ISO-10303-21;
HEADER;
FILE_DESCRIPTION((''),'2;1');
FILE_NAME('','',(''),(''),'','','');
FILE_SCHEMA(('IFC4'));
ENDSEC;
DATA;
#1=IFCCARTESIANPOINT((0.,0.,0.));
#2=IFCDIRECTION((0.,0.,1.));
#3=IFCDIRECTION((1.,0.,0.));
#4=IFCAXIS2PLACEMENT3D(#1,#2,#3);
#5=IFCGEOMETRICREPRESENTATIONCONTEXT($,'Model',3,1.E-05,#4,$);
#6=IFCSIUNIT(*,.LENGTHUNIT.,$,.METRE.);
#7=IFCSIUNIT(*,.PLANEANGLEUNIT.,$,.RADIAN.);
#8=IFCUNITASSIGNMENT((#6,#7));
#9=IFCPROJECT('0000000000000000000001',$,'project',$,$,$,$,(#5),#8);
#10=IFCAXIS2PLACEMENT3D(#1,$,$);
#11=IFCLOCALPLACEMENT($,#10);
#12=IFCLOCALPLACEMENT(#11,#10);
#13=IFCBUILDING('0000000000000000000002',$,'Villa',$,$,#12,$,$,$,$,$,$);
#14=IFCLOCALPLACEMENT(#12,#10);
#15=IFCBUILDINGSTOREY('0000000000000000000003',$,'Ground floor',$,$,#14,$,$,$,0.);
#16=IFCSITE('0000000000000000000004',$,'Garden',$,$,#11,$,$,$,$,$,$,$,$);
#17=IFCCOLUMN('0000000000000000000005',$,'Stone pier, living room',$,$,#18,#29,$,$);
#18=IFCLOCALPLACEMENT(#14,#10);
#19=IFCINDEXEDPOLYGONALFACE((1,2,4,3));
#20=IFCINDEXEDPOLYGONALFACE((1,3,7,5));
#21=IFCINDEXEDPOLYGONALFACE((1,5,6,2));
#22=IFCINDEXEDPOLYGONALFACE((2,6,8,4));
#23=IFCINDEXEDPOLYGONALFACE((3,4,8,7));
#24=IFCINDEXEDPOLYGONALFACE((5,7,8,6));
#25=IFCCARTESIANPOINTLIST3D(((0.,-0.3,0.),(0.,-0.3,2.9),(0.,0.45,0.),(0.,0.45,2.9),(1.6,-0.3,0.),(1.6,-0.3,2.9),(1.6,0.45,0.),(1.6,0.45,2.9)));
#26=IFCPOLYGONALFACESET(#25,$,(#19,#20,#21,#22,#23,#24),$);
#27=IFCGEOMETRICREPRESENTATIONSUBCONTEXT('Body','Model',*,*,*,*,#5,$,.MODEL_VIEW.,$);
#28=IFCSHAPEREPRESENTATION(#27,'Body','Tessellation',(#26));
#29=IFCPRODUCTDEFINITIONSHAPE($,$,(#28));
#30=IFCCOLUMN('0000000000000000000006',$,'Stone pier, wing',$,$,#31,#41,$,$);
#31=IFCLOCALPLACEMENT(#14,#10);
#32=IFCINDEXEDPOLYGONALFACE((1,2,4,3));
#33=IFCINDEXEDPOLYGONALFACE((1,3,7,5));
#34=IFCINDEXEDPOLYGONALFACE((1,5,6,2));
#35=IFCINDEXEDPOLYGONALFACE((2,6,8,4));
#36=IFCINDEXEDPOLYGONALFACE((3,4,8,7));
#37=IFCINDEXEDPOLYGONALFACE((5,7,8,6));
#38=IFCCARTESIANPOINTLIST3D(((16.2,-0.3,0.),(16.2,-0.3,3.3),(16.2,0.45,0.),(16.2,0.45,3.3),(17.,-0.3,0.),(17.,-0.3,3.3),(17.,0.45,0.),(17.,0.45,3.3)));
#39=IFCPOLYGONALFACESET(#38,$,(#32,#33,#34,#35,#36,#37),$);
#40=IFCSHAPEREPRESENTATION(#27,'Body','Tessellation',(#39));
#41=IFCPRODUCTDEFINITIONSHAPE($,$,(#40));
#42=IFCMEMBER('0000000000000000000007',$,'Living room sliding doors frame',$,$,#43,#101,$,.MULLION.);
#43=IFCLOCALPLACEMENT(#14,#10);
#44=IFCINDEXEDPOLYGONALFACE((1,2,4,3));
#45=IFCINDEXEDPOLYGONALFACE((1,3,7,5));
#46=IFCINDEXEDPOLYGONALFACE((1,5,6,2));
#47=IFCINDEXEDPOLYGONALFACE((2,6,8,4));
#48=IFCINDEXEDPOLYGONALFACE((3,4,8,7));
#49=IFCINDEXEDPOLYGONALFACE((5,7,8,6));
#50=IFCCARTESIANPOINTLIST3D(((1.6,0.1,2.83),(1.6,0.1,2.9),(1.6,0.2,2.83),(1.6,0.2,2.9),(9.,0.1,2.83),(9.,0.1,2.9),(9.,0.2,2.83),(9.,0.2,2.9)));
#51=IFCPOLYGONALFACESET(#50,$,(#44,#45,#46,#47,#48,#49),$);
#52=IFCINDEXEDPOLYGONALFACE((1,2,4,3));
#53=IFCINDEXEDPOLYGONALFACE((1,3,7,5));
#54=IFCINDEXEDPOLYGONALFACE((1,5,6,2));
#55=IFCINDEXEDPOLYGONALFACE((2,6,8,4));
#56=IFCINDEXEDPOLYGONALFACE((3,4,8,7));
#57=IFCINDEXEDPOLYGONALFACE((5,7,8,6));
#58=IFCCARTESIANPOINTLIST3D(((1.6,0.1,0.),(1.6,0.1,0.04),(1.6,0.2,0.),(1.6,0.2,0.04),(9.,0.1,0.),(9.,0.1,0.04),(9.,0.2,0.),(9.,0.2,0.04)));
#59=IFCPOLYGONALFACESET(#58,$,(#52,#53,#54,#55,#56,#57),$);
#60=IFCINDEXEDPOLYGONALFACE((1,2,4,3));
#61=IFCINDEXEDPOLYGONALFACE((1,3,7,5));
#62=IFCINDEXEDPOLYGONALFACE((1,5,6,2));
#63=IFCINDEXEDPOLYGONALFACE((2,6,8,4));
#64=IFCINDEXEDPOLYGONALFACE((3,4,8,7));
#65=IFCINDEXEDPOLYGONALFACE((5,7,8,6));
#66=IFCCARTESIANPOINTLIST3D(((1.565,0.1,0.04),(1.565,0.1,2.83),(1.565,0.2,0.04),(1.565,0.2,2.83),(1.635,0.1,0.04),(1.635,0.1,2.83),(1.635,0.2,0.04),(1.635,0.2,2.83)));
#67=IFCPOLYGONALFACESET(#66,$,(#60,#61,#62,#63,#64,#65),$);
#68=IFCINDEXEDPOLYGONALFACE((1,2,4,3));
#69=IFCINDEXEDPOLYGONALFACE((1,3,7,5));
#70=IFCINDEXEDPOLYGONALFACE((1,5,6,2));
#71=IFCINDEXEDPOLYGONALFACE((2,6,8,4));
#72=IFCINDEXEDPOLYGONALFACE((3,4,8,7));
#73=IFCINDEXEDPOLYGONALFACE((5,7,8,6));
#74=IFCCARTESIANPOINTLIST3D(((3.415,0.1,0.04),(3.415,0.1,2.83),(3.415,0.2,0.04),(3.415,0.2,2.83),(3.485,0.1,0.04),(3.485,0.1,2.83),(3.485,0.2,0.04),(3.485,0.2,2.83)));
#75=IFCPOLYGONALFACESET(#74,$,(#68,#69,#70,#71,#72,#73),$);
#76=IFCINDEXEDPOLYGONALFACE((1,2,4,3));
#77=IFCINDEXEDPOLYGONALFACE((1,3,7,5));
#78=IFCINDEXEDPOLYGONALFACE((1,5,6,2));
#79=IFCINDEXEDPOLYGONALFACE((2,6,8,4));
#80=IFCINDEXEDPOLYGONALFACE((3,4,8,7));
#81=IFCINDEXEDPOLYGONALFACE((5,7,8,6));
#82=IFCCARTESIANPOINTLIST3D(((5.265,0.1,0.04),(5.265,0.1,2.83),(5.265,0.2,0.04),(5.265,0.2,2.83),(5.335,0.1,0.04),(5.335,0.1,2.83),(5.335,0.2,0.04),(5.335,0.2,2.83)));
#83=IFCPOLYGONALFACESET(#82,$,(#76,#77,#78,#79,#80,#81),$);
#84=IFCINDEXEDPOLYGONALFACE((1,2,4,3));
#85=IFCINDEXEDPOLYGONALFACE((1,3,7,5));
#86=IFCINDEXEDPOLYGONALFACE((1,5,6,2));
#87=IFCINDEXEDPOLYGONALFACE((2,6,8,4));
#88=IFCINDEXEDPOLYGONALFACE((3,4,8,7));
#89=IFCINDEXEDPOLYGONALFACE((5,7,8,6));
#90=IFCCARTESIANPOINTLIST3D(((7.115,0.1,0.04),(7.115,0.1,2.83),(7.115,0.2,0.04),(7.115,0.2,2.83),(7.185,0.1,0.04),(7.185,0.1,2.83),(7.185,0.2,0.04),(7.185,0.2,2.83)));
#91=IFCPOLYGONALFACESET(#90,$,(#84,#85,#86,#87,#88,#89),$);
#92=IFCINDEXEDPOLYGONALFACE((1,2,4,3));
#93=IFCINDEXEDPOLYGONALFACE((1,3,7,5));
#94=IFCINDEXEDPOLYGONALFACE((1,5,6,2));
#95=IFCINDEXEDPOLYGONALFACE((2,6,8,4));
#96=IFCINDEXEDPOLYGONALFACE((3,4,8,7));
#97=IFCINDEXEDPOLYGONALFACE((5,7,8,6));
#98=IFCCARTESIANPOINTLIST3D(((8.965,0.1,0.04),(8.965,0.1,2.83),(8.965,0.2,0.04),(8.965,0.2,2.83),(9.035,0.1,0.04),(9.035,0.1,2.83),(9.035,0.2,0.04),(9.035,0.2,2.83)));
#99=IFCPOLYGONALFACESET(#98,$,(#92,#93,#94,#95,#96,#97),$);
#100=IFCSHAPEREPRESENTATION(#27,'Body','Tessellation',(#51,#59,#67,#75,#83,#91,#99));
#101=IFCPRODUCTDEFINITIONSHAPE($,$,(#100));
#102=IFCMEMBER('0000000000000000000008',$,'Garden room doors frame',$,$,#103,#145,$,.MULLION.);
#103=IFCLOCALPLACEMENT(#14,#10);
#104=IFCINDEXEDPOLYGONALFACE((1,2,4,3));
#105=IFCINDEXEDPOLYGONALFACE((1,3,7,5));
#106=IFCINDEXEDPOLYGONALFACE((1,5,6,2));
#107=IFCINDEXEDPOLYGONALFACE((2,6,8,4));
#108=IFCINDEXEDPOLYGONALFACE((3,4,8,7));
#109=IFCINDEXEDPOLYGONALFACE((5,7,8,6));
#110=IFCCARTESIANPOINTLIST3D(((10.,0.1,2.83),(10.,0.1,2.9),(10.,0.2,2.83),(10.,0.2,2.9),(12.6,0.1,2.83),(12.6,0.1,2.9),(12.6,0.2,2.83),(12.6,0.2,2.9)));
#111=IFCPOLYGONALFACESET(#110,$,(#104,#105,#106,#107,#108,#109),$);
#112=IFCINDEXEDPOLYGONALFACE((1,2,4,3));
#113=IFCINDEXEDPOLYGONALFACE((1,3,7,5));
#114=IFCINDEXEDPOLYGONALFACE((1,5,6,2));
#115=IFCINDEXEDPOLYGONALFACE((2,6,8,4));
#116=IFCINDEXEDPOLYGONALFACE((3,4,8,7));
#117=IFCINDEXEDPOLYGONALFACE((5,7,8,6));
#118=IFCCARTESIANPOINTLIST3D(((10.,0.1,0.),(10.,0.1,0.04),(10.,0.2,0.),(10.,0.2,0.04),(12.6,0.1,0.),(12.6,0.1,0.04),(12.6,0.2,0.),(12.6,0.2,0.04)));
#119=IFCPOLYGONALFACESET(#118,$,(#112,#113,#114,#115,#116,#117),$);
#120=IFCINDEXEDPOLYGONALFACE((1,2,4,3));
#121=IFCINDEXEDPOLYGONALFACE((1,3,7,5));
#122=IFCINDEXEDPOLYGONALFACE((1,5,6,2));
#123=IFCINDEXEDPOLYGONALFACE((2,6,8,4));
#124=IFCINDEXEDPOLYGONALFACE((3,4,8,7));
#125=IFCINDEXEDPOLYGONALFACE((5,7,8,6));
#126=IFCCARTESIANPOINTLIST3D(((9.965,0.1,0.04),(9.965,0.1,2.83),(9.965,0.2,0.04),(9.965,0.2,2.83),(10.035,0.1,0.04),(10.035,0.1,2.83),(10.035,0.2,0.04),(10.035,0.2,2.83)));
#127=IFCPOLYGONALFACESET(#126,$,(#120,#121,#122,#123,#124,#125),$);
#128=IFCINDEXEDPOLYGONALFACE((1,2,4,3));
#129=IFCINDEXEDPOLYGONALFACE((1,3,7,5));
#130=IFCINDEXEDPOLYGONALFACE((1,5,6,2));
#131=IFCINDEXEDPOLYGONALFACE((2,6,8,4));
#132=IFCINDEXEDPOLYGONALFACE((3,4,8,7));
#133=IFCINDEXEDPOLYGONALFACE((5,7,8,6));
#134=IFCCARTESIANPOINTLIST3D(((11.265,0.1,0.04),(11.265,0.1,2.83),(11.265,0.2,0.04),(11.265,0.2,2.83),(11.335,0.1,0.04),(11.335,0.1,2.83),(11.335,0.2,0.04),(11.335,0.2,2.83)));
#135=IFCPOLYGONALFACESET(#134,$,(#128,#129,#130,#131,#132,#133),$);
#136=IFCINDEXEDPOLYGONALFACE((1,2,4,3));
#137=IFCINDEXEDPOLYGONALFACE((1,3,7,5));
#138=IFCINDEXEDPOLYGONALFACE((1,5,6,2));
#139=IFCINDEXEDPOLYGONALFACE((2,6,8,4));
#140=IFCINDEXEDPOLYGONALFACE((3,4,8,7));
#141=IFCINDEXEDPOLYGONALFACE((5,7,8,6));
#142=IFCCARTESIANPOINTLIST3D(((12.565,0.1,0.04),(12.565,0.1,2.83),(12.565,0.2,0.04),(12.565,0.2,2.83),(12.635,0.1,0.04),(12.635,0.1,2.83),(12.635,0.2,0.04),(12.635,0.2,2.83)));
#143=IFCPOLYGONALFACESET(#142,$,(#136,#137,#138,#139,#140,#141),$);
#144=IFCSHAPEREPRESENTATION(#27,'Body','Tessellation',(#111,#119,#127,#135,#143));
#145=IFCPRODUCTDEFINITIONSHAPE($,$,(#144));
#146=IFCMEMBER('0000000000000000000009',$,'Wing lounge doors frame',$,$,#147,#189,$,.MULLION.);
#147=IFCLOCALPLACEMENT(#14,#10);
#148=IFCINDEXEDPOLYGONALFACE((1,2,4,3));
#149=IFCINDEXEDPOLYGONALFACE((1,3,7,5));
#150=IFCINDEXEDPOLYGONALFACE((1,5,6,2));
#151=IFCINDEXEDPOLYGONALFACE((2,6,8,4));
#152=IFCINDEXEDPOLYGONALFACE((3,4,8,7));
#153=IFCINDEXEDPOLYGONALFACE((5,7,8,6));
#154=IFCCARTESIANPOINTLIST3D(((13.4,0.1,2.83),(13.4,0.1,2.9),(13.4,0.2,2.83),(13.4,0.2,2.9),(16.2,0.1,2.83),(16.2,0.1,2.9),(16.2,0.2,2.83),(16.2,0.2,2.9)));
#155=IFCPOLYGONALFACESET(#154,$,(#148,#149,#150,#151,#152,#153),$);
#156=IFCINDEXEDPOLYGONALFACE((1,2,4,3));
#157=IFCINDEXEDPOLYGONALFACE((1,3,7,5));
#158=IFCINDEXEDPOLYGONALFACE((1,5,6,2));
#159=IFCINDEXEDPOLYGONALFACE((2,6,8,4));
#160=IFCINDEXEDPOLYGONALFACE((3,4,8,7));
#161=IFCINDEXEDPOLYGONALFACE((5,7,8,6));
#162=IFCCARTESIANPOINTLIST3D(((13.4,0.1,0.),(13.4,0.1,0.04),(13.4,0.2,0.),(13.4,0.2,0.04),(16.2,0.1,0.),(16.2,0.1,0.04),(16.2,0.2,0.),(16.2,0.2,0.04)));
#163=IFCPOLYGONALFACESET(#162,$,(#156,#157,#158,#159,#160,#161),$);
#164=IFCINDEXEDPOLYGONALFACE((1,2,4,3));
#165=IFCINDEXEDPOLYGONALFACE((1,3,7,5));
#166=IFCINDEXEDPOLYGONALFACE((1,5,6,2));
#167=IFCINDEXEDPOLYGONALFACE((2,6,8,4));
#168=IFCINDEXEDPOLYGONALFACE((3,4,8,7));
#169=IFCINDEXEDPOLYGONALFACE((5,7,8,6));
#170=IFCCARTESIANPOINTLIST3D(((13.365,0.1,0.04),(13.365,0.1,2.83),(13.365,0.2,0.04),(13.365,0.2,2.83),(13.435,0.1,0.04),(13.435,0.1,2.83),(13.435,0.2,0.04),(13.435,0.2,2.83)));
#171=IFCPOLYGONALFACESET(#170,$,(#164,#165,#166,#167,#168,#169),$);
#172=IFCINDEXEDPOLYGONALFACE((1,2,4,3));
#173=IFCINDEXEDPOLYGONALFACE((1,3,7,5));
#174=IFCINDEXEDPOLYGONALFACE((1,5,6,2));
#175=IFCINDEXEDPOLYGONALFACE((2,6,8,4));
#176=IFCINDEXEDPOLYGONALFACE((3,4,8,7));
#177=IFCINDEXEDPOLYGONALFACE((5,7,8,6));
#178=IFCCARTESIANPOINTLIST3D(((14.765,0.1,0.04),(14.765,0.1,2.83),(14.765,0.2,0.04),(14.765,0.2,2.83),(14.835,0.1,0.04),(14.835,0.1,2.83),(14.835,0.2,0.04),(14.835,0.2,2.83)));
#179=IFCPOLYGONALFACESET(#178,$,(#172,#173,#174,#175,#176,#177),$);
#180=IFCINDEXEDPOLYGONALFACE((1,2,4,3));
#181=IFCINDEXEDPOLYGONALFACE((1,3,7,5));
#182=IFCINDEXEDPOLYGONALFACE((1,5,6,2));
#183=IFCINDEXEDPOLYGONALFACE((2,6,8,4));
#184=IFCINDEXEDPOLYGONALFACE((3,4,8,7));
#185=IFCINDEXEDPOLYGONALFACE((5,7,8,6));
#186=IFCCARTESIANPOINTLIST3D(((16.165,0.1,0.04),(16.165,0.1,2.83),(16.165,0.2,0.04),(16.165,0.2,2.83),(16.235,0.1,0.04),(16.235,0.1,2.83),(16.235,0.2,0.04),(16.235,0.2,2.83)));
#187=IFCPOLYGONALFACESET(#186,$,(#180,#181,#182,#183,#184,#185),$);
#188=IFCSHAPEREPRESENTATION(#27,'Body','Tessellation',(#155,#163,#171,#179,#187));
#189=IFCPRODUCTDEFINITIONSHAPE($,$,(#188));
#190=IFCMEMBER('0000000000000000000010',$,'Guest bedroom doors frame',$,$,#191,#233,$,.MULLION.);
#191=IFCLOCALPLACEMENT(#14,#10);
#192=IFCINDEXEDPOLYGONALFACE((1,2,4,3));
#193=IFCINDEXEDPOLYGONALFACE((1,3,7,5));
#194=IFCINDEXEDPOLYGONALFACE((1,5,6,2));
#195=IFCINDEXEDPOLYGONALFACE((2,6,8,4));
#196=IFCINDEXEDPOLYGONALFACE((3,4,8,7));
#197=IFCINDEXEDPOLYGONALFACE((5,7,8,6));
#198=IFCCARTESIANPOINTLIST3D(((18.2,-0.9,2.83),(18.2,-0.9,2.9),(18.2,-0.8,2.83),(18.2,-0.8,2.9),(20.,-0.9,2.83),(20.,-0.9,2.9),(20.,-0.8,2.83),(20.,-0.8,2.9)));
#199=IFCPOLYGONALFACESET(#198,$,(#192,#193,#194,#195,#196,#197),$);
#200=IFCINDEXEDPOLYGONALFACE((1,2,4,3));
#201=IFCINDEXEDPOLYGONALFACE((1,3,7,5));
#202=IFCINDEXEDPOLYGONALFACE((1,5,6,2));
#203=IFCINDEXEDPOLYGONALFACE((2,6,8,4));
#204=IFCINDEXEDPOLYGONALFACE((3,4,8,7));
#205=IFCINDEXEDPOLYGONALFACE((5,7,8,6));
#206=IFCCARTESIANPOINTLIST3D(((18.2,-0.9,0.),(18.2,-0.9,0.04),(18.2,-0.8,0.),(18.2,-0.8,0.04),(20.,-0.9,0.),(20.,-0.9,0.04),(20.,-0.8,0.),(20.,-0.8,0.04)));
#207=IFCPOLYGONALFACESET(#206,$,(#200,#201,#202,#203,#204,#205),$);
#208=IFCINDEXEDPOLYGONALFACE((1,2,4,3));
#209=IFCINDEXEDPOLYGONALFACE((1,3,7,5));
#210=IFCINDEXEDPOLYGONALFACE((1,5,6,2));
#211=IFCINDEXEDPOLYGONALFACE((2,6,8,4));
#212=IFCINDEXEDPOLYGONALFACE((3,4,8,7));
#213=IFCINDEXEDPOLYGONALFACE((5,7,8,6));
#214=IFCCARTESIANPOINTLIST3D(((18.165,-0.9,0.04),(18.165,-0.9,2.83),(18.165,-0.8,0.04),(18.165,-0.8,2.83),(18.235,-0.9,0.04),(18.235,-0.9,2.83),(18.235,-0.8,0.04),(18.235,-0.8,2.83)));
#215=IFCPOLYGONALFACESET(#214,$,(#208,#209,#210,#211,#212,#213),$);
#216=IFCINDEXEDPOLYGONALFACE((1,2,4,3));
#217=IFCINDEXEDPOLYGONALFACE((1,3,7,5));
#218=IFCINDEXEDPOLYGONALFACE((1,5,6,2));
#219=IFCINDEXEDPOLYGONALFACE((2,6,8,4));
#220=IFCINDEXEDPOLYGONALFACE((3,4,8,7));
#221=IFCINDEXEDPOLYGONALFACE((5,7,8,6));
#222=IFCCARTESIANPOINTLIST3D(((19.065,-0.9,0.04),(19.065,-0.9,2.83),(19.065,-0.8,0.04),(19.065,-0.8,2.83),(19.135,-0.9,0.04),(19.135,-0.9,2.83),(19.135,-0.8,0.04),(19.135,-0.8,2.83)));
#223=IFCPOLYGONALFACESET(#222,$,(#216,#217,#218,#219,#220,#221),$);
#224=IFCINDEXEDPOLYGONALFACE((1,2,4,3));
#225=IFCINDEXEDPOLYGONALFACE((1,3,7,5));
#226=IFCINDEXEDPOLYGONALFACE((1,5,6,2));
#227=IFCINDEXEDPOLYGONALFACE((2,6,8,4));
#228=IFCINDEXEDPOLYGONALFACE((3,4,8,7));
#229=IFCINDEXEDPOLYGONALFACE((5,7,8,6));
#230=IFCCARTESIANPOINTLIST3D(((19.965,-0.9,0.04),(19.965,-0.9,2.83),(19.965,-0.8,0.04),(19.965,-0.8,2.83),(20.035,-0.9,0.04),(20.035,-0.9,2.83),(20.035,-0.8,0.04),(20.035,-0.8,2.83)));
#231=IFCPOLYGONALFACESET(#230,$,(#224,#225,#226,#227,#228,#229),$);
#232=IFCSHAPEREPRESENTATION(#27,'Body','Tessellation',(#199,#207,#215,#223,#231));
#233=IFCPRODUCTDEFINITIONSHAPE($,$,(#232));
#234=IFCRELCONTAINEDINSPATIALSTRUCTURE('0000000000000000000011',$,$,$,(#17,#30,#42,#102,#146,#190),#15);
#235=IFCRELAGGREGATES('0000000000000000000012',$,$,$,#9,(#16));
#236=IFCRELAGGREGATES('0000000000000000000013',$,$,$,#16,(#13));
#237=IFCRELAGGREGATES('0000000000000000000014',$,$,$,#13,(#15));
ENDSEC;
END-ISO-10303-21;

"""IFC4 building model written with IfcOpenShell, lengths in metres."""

from ifc_helpers import new_model, si_unit, frame, frame_2d, origin, origin_with_axes, place, context, subcontext, project, spatial, rectangle, extrude, element, save


model = new_model("IFC4")

# Units and contexts
model_context = context("Model", 3, precision=1e-05, world=origin_with_axes())
body_context = subcontext(model_context, "Body", "Model", "MODEL_VIEW")
ifc_project = project(units=[si_unit("LENGTHUNIT", "METRE"), si_unit("PLANEANGLEUNIT", "RADIAN")], contexts=[model_context])

# Site, building, storey
site_placement = place(None, origin())
site = spatial("IfcSite", under=ifc_project, at=site_placement, Name="Garden")
building_placement = place(site_placement, origin())
building = spatial("IfcBuilding", under=site, at=building_placement, Name="Villa")
storey_placement = place(building_placement, origin())
storey = spatial("IfcBuildingStorey", under=building, at=storey_placement, Name="Ground floor", Elevation=0.0)

# Columns
column_1_placement = place(storey_placement, origin())
element("IfcColumn", 1, at=column_1_placement, inside=storey, Name="Stone pier, living room", context=body_context, shape_type="SweptSolid", body=[
    extrude(rectangle(XDim=1.6, YDim=0.75, at=frame_2d((0.8, 0.375))), frame((0.0, -0.3, 0.0)), (0.0, 0.0, 1.0), 2.9),
])
column_2_placement = place(storey_placement, origin())
element("IfcColumn", 2, at=column_2_placement, inside=storey, Name="Stone pier, wing", context=body_context, shape_type="SweptSolid", body=[
    extrude(rectangle(XDim=0.8, YDim=0.75, at=frame_2d((0.4, 0.375))), frame((16.2, -0.3, 0.0)), (0.0, 0.0, 1.0), 3.3),
])

# Members
member_1_placement = place(storey_placement, origin())
element("IfcMember", 3, at=member_1_placement, inside=storey, Name="Living room sliding doors frame", PredefinedType="MULLION", context=body_context, shape_type="SweptSolid", body=[
    extrude(rectangle(XDim=7.4, YDim=0.1, at=frame_2d((3.7, 0.05))), frame((1.6, 0.1, 2.83)), (0.0, 0.0, 1.0), 0.07),
    extrude(rectangle(XDim=7.4, YDim=0.1, at=frame_2d((3.7, 0.05))), frame((1.6, 0.1, 0.0)), (0.0, 0.0, 1.0), 0.04),
    extrude(rectangle(XDim=0.07, YDim=0.1, at=frame_2d((0.035, 0.05))), frame((1.565, 0.1, 0.04)), (0.0, 0.0, 1.0), 2.79),
    extrude(rectangle(XDim=0.07, YDim=0.1, at=frame_2d((0.035, 0.05))), frame((3.415, 0.1, 0.04)), (0.0, 0.0, 1.0), 2.79),
    extrude(rectangle(XDim=0.07, YDim=0.1, at=frame_2d((0.035, 0.05))), frame((5.265, 0.1, 0.04)), (0.0, 0.0, 1.0), 2.79),
    extrude(rectangle(XDim=0.07, YDim=0.1, at=frame_2d((0.035, 0.05))), frame((7.115, 0.1, 0.04)), (0.0, 0.0, 1.0), 2.79),
    extrude(rectangle(XDim=0.07, YDim=0.1, at=frame_2d((0.035, 0.05))), frame((8.965, 0.1, 0.04)), (0.0, 0.0, 1.0), 2.79),
])
member_2_placement = place(storey_placement, origin())
element("IfcMember", 4, at=member_2_placement, inside=storey, Name="Garden room doors frame", PredefinedType="MULLION", context=body_context, shape_type="SweptSolid", body=[
    extrude(rectangle(XDim=2.6, YDim=0.1, at=frame_2d((1.3, 0.05))), frame((10.0, 0.1, 2.83)), (0.0, 0.0, 1.0), 0.07),
    extrude(rectangle(XDim=2.6, YDim=0.1, at=frame_2d((1.3, 0.05))), frame((10.0, 0.1, 0.0)), (0.0, 0.0, 1.0), 0.04),
    extrude(rectangle(XDim=0.07, YDim=0.1, at=frame_2d((0.035, 0.05))), frame((9.965, 0.1, 0.04)), (0.0, 0.0, 1.0), 2.79),
    extrude(rectangle(XDim=0.07, YDim=0.1, at=frame_2d((0.035, 0.05))), frame((11.265, 0.1, 0.04)), (0.0, 0.0, 1.0), 2.79),
    extrude(rectangle(XDim=0.07, YDim=0.1, at=frame_2d((0.035, 0.05))), frame((12.565, 0.1, 0.04)), (0.0, 0.0, 1.0), 2.79),
])
member_3_placement = place(storey_placement, origin())
element("IfcMember", 5, at=member_3_placement, inside=storey, Name="Wing lounge doors frame", PredefinedType="MULLION", context=body_context, shape_type="SweptSolid", body=[
    extrude(rectangle(XDim=2.8, YDim=0.1, at=frame_2d((1.4, 0.05))), frame((13.4, 0.1, 2.83)), (0.0, 0.0, 1.0), 0.07),
    extrude(rectangle(XDim=2.8, YDim=0.1, at=frame_2d((1.4, 0.05))), frame((13.4, 0.1, 0.0)), (0.0, 0.0, 1.0), 0.04),
    extrude(rectangle(XDim=0.07, YDim=0.1, at=frame_2d((0.035, 0.05))), frame((13.365, 0.1, 0.04)), (0.0, 0.0, 1.0), 2.79),
    extrude(rectangle(XDim=0.07, YDim=0.1, at=frame_2d((0.035, 0.05))), frame((14.765, 0.1, 0.04)), (0.0, 0.0, 1.0), 2.79),
    extrude(rectangle(XDim=0.07, YDim=0.1, at=frame_2d((0.035, 0.05))), frame((16.165, 0.1, 0.04)), (0.0, 0.0, 1.0), 2.79),
])
member_4_placement = place(storey_placement, origin())
element("IfcMember", 6, at=member_4_placement, inside=storey, Name="Guest bedroom doors frame", PredefinedType="MULLION", context=body_context, shape_type="SweptSolid", body=[
    extrude(rectangle(XDim=1.8, YDim=0.1, at=frame_2d((0.9, 0.05))), frame((18.2, -0.9, 2.83)), (0.0, 0.0, 1.0), 0.07),
    extrude(rectangle(XDim=1.8, YDim=0.1, at=frame_2d((0.9, 0.05))), frame((18.2, -0.9, 0.0)), (0.0, 0.0, 1.0), 0.04),
    extrude(rectangle(XDim=0.07, YDim=0.1, at=frame_2d((0.035, 0.05))), frame((18.165, -0.9, 0.04)), (0.0, 0.0, 1.0), 2.79),
    extrude(rectangle(XDim=0.07, YDim=0.1, at=frame_2d((0.035, 0.05))), frame((19.065, -0.9, 0.04)), (0.0, 0.0, 1.0), 2.79),
    extrude(rectangle(XDim=0.07, YDim=0.1, at=frame_2d((0.035, 0.05))), frame((19.965, -0.9, 0.04)), (0.0, 0.0, 1.0), 2.79),
])

save(model, "model.ifc")
